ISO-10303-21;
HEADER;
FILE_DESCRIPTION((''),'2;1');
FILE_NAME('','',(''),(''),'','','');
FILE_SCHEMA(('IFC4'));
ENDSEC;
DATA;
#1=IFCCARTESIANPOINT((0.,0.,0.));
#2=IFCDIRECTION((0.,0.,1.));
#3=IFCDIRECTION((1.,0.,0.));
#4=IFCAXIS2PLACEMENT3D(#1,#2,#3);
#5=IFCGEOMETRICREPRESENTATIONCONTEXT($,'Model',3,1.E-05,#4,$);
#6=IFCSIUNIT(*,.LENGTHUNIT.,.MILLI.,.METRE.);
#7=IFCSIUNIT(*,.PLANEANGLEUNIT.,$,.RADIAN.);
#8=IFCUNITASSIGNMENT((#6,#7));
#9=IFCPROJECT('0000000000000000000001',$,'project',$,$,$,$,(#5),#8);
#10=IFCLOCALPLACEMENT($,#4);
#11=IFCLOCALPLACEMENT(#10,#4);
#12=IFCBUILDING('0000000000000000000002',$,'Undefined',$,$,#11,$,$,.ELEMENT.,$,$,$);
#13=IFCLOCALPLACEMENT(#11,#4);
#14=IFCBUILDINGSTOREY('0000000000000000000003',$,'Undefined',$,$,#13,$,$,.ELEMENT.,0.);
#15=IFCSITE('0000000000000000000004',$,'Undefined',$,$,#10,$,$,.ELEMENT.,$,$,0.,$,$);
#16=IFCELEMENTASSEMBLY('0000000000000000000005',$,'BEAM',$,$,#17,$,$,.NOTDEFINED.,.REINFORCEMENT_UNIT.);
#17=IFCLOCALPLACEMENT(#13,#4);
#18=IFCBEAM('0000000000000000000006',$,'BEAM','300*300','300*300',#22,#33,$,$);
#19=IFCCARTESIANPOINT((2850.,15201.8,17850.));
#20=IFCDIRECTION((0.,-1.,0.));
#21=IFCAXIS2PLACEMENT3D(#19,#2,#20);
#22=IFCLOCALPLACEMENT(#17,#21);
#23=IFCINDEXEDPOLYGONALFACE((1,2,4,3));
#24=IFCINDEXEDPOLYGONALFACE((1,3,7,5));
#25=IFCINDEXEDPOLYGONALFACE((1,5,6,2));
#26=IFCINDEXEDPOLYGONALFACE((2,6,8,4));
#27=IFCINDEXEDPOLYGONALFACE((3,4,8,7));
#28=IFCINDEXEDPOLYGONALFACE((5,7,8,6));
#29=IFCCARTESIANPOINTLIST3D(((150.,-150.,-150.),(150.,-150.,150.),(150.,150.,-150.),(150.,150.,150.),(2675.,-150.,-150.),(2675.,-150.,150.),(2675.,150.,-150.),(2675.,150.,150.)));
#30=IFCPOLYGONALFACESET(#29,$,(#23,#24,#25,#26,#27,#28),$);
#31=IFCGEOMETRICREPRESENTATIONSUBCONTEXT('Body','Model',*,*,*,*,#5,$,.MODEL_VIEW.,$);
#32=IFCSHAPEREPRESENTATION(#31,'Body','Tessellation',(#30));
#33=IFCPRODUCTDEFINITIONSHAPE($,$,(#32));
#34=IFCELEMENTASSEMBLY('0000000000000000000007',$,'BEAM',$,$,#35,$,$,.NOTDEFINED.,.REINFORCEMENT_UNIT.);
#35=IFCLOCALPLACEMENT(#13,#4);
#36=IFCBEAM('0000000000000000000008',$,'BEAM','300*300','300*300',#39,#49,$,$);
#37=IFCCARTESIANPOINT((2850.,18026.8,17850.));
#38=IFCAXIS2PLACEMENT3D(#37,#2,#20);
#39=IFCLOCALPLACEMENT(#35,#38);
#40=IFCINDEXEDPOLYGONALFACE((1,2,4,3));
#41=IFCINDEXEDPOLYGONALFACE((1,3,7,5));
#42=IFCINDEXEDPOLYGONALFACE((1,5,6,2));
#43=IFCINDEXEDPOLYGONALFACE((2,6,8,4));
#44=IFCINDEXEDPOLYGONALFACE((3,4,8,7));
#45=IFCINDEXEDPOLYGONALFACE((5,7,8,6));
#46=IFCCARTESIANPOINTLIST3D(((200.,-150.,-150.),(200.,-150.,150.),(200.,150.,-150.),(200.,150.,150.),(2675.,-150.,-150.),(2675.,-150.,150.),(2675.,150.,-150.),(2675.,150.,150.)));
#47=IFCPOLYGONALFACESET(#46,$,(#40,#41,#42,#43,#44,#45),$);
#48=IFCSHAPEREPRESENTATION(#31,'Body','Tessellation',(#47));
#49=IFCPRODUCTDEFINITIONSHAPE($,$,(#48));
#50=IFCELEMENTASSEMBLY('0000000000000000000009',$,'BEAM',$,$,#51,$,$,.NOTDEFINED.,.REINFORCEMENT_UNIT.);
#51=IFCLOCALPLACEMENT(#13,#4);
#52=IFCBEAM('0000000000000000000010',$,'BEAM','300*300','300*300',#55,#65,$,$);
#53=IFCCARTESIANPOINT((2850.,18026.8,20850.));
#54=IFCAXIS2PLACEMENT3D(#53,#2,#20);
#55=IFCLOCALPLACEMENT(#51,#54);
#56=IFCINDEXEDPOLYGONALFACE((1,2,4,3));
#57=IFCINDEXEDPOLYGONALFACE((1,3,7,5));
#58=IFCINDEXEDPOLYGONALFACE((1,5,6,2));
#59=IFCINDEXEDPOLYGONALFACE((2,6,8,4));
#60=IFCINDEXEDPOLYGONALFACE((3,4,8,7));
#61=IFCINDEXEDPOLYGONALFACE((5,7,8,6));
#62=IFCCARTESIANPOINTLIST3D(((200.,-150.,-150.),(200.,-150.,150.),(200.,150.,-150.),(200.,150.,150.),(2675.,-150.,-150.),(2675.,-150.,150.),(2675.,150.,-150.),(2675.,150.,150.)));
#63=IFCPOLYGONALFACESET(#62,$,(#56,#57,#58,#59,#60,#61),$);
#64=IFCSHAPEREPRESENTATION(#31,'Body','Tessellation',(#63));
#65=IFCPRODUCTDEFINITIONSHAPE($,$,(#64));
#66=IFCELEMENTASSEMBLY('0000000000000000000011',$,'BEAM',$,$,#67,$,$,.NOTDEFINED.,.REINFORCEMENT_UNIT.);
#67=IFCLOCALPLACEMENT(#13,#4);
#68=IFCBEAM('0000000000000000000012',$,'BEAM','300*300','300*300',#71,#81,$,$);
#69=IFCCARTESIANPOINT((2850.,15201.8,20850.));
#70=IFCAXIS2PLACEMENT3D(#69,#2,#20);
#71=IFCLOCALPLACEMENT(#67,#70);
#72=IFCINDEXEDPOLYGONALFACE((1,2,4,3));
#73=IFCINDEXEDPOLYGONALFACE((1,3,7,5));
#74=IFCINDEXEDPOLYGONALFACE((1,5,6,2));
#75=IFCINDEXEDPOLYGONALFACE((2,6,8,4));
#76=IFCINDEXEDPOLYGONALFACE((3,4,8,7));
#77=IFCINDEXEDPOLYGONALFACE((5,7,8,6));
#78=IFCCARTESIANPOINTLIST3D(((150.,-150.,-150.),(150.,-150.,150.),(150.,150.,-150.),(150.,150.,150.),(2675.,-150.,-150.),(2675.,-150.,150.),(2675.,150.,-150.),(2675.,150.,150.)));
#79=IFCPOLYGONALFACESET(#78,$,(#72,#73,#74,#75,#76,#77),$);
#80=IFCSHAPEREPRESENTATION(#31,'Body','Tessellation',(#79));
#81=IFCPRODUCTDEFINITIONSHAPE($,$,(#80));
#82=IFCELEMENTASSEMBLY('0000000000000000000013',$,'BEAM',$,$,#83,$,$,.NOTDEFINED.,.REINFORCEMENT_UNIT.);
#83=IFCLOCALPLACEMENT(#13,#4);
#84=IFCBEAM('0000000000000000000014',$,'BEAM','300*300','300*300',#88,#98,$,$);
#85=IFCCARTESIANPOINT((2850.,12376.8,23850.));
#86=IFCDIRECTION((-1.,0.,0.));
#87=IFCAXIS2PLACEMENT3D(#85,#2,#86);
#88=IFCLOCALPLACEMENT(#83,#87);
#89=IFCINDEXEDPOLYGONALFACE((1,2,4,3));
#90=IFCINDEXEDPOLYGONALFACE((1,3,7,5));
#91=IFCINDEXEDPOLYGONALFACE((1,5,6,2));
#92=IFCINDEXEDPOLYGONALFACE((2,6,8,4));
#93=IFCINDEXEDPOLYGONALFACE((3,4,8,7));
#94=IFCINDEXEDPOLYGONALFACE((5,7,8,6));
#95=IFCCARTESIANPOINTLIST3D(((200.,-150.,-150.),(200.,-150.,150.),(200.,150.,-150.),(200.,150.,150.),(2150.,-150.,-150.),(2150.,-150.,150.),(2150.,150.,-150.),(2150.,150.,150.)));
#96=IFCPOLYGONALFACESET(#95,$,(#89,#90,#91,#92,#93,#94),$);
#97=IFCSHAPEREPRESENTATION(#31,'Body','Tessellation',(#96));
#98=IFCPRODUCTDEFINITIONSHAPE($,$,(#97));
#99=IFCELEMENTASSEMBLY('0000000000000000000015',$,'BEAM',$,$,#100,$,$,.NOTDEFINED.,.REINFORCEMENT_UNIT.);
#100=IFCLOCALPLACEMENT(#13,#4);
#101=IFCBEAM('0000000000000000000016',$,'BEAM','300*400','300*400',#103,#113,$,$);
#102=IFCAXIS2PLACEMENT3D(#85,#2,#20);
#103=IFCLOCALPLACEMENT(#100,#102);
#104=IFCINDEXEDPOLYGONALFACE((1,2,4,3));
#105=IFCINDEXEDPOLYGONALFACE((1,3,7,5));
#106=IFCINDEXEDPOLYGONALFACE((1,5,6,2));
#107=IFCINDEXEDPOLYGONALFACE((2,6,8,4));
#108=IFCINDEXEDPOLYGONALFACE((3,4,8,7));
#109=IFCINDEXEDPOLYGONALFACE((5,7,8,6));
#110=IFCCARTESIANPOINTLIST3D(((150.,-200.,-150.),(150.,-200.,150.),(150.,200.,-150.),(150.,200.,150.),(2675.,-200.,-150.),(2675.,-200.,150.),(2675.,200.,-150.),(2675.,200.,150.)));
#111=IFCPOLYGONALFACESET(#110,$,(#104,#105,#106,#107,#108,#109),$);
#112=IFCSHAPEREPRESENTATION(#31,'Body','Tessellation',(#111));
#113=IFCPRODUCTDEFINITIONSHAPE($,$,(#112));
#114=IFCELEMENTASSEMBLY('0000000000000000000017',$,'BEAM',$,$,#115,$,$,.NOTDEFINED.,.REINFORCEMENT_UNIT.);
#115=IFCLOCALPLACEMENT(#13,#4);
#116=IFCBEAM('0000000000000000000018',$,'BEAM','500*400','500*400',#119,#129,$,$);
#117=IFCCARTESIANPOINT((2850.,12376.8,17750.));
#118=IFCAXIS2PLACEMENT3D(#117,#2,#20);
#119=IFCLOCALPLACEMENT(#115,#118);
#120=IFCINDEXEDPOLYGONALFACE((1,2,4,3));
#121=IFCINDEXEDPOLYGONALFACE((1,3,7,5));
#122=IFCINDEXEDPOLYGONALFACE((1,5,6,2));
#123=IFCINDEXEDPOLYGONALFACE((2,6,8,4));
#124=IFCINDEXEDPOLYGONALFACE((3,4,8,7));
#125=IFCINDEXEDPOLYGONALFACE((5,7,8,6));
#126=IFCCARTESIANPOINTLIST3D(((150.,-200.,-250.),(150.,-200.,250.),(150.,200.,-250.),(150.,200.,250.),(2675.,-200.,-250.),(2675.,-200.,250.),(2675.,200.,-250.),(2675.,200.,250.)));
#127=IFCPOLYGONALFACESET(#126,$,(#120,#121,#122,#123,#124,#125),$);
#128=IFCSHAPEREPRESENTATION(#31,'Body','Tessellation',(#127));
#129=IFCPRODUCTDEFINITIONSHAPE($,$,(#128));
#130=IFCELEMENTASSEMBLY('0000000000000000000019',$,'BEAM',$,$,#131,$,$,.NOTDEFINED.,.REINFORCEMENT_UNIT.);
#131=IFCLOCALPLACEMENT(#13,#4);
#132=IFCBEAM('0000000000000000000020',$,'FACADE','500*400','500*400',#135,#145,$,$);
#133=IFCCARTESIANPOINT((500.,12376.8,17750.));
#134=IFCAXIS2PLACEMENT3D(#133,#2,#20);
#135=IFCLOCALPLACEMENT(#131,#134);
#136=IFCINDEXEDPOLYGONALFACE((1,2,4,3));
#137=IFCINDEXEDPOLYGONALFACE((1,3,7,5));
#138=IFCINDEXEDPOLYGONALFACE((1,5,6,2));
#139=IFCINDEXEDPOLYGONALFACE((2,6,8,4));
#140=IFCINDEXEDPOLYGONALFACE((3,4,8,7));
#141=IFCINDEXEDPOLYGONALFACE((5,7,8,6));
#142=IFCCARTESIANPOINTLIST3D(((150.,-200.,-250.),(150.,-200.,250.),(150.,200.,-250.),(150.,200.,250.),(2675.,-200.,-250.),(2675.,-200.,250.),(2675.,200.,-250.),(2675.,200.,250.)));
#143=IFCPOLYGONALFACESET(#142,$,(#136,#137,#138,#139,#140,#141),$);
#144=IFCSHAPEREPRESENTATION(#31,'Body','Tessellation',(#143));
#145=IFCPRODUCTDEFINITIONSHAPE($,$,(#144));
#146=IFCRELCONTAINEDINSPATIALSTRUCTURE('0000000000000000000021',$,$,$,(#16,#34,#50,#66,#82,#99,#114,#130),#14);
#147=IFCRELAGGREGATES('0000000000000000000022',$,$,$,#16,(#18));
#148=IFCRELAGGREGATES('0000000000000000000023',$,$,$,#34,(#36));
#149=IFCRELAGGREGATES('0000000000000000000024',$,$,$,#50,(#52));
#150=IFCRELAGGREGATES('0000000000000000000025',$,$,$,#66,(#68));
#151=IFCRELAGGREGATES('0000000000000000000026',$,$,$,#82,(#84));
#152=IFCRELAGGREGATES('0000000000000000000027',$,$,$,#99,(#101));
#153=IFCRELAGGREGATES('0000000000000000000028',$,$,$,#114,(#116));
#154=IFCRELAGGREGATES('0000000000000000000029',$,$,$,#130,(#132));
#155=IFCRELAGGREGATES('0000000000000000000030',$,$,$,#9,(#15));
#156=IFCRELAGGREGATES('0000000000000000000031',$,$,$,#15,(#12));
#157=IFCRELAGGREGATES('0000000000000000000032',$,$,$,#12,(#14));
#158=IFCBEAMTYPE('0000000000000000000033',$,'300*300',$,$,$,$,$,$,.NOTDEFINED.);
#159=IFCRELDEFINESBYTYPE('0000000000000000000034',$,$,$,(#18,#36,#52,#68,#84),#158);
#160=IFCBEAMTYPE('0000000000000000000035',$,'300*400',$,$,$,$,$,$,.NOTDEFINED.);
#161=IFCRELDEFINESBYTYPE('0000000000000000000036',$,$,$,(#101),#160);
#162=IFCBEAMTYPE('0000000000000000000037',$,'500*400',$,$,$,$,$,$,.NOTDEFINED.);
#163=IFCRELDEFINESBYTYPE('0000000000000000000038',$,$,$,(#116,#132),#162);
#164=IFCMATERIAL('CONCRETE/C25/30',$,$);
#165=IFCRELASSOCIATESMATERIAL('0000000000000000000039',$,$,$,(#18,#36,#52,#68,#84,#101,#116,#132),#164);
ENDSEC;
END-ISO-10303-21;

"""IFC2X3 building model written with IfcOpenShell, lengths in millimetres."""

from ifc_helpers import new_model, si_unit, frame, origin_with_axes, origin_2d_with_axis, place, context, subcontext, project, spatial, rectangle, extrude, material, type_object, element, aggregate, save


model = new_model("IFC2X3")

# Units and contexts
model_context = context("Model", 3, precision=1e-05, world=origin_with_axes())
body_context = subcontext(model_context, "Body", "Model", "MODEL_VIEW")
ifc_project = project(units=[si_unit("LENGTHUNIT", "METRE", prefix="MILLI"), si_unit("PLANEANGLEUNIT", "RADIAN")], contexts=[model_context])

# Site, building, storey
site_placement = place(None, origin_with_axes())
site = spatial("IfcSite", under=ifc_project, at=site_placement, Name="Undefined", CompositionType="ELEMENT", RefElevation=0.0)
building_placement = place(site_placement, origin_with_axes())
building = spatial("IfcBuilding", under=site, at=building_placement, Name="Undefined", CompositionType="ELEMENT")
storey_placement = place(building_placement, origin_with_axes())
storey = spatial("IfcBuildingStorey", under=building, at=storey_placement, Name="Undefined", CompositionType="ELEMENT", Elevation=0.0)

# Shared definitions
ifc_material = material(Name="CONCRETE/C25/30")

# Element assemblies, beams
assembly_1_placement = place(storey_placement, origin_with_axes())
assembly_1 = element("IfcElementAssembly", 1, at=assembly_1_placement, inside=storey, Name="BEAM", AssemblyPlace="NOTDEFINED", PredefinedType="REINFORCEMENT_UNIT")
beam_type_1 = type_object("IfcBeamType", Name="300*300", PredefinedType="NOTDEFINED")
beam_1_placement = place(assembly_1_placement, frame((2850.0, 15201.8, 17850.0), z_axis=(0.0, 0.0, 1.0), x_axis=(0.0, -1.0, 0.0)))
beam_1 = element("IfcBeam", 2, at=beam_1_placement, type_object=beam_type_1, material=ifc_material, Name="BEAM", Description="300*300", ObjectType="300*300", context=body_context, shape_type="SweptSolid", body=[
    extrude(rectangle(XDim=300.0, YDim=300.0, at=origin_2d_with_axis()), frame((2675.0, 0.0, 0.0), z_axis=(-1.0, 0.0, 0.0), x_axis=(0.0, -1.0, 0.0)), (0.0, 0.0, 1.0), 2525.0),
])
aggregate(assembly_1, [beam_1])
assembly_2_placement = place(storey_placement, origin_with_axes())
assembly_2 = element("IfcElementAssembly", 3, at=assembly_2_placement, inside=storey, Name="BEAM", AssemblyPlace="NOTDEFINED", PredefinedType="REINFORCEMENT_UNIT")
beam_2_placement = place(assembly_2_placement, frame((2850.0, 18026.8, 17850.0), z_axis=(0.0, 0.0, 1.0), x_axis=(0.0, -1.0, 0.0)))
beam_2 = element("IfcBeam", 4, at=beam_2_placement, type_object=beam_type_1, material=ifc_material, Name="BEAM", Description="300*300", ObjectType="300*300", context=body_context, shape_type="SweptSolid", body=[
    extrude(rectangle(XDim=300.0, YDim=300.0, at=origin_2d_with_axis()), frame((2675.0, 0.0, 0.0), z_axis=(-1.0, 0.0, 0.0), x_axis=(0.0, -1.0, 0.0)), (0.0, 0.0, 1.0), 2475.0),
])
aggregate(assembly_2, [beam_2])
assembly_3_placement = place(storey_placement, origin_with_axes())
assembly_3 = element("IfcElementAssembly", 5, at=assembly_3_placement, inside=storey, Name="BEAM", AssemblyPlace="NOTDEFINED", PredefinedType="REINFORCEMENT_UNIT")
beam_3_placement = place(assembly_3_placement, frame((2850.0, 18026.8, 20850.0), z_axis=(0.0, 0.0, 1.0), x_axis=(0.0, -1.0, 0.0)))
beam_3 = element("IfcBeam", 6, at=beam_3_placement, type_object=beam_type_1, material=ifc_material, Name="BEAM", Description="300*300", ObjectType="300*300", context=body_context, shape_type="SweptSolid", body=[
    extrude(rectangle(XDim=300.0, YDim=300.0, at=origin_2d_with_axis()), frame((2675.0, 0.0, 0.0), z_axis=(-1.0, 0.0, 0.0), x_axis=(0.0, -1.0, 0.0)), (0.0, 0.0, 1.0), 2475.0),
])
aggregate(assembly_3, [beam_3])
assembly_4_placement = place(storey_placement, origin_with_axes())
assembly_4 = element("IfcElementAssembly", 7, at=assembly_4_placement, inside=storey, Name="BEAM", AssemblyPlace="NOTDEFINED", PredefinedType="REINFORCEMENT_UNIT")
beam_4_placement = place(assembly_4_placement, frame((2850.0, 15201.8, 20850.0), z_axis=(0.0, 0.0, 1.0), x_axis=(0.0, -1.0, 0.0)))
beam_4 = element("IfcBeam", 8, at=beam_4_placement, type_object=beam_type_1, material=ifc_material, Name="BEAM", Description="300*300", ObjectType="300*300", context=body_context, shape_type="SweptSolid", body=[
    extrude(rectangle(XDim=300.0, YDim=300.0, at=origin_2d_with_axis()), frame((2675.0, 0.0, 0.0), z_axis=(-1.0, 0.0, 0.0), x_axis=(0.0, -1.0, 0.0)), (0.0, 0.0, 1.0), 2525.0),
])
aggregate(assembly_4, [beam_4])
assembly_5_placement = place(storey_placement, origin_with_axes())
assembly_5 = element("IfcElementAssembly", 9, at=assembly_5_placement, inside=storey, Name="BEAM", AssemblyPlace="NOTDEFINED", PredefinedType="REINFORCEMENT_UNIT")
beam_5_placement = place(assembly_5_placement, frame((2850.0, 12376.8, 23850.0), z_axis=(0.0, 0.0, 1.0), x_axis=(-1.0, 0.0, 0.0)))
beam_5 = element("IfcBeam", 10, at=beam_5_placement, type_object=beam_type_1, material=ifc_material, Name="BEAM", Description="300*300", ObjectType="300*300", context=body_context, shape_type="SweptSolid", body=[
    extrude(rectangle(XDim=300.0, YDim=300.0, at=origin_2d_with_axis()), frame((2150.0, 0.0, 0.0), z_axis=(-1.0, 0.0, 0.0), x_axis=(0.0, -1.0, 0.0)), (0.0, 0.0, 1.0), 1950.0),
])
aggregate(assembly_5, [beam_5])
assembly_6_placement = place(storey_placement, origin_with_axes())
assembly_6 = element("IfcElementAssembly", 11, at=assembly_6_placement, inside=storey, Name="BEAM", AssemblyPlace="NOTDEFINED", PredefinedType="REINFORCEMENT_UNIT")
beam_type_2 = type_object("IfcBeamType", Name="300*400", PredefinedType="NOTDEFINED")
beam_6_placement = place(assembly_6_placement, frame((2850.0, 12376.8, 23850.0), z_axis=(0.0, 0.0, 1.0), x_axis=(0.0, -1.0, 0.0)))
beam_6 = element("IfcBeam", 12, at=beam_6_placement, type_object=beam_type_2, material=ifc_material, Name="BEAM", Description="300*400", ObjectType="300*400", context=body_context, shape_type="SweptSolid", body=[
    extrude(rectangle(XDim=400.0, YDim=300.0, at=origin_2d_with_axis()), frame((2675.0, 0.0, 0.0), z_axis=(-1.0, 0.0, 0.0), x_axis=(0.0, -1.0, 0.0)), (0.0, 0.0, 1.0), 2525.0),
])
aggregate(assembly_6, [beam_6])
assembly_7_placement = place(storey_placement, origin_with_axes())
assembly_7 = element("IfcElementAssembly", 13, at=assembly_7_placement, inside=storey, Name="BEAM", AssemblyPlace="NOTDEFINED", PredefinedType="REINFORCEMENT_UNIT")
beam_type_3 = type_object("IfcBeamType", Name="500*400", PredefinedType="NOTDEFINED")
beam_7_placement = place(assembly_7_placement, frame((2850.0, 12376.8, 17750.0), z_axis=(0.0, 0.0, 1.0), x_axis=(0.0, -1.0, 0.0)))
beam_7 = element("IfcBeam", 14, at=beam_7_placement, type_object=beam_type_3, material=ifc_material, Name="BEAM", Description="500*400", ObjectType="500*400", context=body_context, shape_type="SweptSolid", body=[
    extrude(rectangle(XDim=400.0, YDim=500.0, at=origin_2d_with_axis()), frame((2675.0, 0.0, 0.0), z_axis=(-1.0, 0.0, 0.0), x_axis=(0.0, -1.0, 0.0)), (0.0, 0.0, 1.0), 2525.0),
])
aggregate(assembly_7, [beam_7])
assembly_8_placement = place(storey_placement, origin_with_axes())
assembly_8 = element("IfcElementAssembly", 15, at=assembly_8_placement, inside=storey, Name="BEAM", AssemblyPlace="NOTDEFINED", PredefinedType="REINFORCEMENT_UNIT")
beam_8_placement = place(assembly_8_placement, frame((500.0, 12376.8, 17750.0), z_axis=(0.0, 0.0, 1.0), x_axis=(0.0, -1.0, 0.0)))
beam_8 = element("IfcBeam", 16, at=beam_8_placement, type_object=beam_type_3, material=ifc_material, Name="FACADE", Description="500*400", ObjectType="500*400", context=body_context, shape_type="SweptSolid", body=[
    extrude(rectangle(XDim=400.0, YDim=500.0, at=origin_2d_with_axis()), frame((2675.0, 0.0, 0.0), z_axis=(-1.0, 0.0, 0.0), x_axis=(0.0, -1.0, 0.0)), (0.0, 0.0, 1.0), 2525.0),
])
aggregate(assembly_8, [beam_8])

save(model, "model.ifc")
